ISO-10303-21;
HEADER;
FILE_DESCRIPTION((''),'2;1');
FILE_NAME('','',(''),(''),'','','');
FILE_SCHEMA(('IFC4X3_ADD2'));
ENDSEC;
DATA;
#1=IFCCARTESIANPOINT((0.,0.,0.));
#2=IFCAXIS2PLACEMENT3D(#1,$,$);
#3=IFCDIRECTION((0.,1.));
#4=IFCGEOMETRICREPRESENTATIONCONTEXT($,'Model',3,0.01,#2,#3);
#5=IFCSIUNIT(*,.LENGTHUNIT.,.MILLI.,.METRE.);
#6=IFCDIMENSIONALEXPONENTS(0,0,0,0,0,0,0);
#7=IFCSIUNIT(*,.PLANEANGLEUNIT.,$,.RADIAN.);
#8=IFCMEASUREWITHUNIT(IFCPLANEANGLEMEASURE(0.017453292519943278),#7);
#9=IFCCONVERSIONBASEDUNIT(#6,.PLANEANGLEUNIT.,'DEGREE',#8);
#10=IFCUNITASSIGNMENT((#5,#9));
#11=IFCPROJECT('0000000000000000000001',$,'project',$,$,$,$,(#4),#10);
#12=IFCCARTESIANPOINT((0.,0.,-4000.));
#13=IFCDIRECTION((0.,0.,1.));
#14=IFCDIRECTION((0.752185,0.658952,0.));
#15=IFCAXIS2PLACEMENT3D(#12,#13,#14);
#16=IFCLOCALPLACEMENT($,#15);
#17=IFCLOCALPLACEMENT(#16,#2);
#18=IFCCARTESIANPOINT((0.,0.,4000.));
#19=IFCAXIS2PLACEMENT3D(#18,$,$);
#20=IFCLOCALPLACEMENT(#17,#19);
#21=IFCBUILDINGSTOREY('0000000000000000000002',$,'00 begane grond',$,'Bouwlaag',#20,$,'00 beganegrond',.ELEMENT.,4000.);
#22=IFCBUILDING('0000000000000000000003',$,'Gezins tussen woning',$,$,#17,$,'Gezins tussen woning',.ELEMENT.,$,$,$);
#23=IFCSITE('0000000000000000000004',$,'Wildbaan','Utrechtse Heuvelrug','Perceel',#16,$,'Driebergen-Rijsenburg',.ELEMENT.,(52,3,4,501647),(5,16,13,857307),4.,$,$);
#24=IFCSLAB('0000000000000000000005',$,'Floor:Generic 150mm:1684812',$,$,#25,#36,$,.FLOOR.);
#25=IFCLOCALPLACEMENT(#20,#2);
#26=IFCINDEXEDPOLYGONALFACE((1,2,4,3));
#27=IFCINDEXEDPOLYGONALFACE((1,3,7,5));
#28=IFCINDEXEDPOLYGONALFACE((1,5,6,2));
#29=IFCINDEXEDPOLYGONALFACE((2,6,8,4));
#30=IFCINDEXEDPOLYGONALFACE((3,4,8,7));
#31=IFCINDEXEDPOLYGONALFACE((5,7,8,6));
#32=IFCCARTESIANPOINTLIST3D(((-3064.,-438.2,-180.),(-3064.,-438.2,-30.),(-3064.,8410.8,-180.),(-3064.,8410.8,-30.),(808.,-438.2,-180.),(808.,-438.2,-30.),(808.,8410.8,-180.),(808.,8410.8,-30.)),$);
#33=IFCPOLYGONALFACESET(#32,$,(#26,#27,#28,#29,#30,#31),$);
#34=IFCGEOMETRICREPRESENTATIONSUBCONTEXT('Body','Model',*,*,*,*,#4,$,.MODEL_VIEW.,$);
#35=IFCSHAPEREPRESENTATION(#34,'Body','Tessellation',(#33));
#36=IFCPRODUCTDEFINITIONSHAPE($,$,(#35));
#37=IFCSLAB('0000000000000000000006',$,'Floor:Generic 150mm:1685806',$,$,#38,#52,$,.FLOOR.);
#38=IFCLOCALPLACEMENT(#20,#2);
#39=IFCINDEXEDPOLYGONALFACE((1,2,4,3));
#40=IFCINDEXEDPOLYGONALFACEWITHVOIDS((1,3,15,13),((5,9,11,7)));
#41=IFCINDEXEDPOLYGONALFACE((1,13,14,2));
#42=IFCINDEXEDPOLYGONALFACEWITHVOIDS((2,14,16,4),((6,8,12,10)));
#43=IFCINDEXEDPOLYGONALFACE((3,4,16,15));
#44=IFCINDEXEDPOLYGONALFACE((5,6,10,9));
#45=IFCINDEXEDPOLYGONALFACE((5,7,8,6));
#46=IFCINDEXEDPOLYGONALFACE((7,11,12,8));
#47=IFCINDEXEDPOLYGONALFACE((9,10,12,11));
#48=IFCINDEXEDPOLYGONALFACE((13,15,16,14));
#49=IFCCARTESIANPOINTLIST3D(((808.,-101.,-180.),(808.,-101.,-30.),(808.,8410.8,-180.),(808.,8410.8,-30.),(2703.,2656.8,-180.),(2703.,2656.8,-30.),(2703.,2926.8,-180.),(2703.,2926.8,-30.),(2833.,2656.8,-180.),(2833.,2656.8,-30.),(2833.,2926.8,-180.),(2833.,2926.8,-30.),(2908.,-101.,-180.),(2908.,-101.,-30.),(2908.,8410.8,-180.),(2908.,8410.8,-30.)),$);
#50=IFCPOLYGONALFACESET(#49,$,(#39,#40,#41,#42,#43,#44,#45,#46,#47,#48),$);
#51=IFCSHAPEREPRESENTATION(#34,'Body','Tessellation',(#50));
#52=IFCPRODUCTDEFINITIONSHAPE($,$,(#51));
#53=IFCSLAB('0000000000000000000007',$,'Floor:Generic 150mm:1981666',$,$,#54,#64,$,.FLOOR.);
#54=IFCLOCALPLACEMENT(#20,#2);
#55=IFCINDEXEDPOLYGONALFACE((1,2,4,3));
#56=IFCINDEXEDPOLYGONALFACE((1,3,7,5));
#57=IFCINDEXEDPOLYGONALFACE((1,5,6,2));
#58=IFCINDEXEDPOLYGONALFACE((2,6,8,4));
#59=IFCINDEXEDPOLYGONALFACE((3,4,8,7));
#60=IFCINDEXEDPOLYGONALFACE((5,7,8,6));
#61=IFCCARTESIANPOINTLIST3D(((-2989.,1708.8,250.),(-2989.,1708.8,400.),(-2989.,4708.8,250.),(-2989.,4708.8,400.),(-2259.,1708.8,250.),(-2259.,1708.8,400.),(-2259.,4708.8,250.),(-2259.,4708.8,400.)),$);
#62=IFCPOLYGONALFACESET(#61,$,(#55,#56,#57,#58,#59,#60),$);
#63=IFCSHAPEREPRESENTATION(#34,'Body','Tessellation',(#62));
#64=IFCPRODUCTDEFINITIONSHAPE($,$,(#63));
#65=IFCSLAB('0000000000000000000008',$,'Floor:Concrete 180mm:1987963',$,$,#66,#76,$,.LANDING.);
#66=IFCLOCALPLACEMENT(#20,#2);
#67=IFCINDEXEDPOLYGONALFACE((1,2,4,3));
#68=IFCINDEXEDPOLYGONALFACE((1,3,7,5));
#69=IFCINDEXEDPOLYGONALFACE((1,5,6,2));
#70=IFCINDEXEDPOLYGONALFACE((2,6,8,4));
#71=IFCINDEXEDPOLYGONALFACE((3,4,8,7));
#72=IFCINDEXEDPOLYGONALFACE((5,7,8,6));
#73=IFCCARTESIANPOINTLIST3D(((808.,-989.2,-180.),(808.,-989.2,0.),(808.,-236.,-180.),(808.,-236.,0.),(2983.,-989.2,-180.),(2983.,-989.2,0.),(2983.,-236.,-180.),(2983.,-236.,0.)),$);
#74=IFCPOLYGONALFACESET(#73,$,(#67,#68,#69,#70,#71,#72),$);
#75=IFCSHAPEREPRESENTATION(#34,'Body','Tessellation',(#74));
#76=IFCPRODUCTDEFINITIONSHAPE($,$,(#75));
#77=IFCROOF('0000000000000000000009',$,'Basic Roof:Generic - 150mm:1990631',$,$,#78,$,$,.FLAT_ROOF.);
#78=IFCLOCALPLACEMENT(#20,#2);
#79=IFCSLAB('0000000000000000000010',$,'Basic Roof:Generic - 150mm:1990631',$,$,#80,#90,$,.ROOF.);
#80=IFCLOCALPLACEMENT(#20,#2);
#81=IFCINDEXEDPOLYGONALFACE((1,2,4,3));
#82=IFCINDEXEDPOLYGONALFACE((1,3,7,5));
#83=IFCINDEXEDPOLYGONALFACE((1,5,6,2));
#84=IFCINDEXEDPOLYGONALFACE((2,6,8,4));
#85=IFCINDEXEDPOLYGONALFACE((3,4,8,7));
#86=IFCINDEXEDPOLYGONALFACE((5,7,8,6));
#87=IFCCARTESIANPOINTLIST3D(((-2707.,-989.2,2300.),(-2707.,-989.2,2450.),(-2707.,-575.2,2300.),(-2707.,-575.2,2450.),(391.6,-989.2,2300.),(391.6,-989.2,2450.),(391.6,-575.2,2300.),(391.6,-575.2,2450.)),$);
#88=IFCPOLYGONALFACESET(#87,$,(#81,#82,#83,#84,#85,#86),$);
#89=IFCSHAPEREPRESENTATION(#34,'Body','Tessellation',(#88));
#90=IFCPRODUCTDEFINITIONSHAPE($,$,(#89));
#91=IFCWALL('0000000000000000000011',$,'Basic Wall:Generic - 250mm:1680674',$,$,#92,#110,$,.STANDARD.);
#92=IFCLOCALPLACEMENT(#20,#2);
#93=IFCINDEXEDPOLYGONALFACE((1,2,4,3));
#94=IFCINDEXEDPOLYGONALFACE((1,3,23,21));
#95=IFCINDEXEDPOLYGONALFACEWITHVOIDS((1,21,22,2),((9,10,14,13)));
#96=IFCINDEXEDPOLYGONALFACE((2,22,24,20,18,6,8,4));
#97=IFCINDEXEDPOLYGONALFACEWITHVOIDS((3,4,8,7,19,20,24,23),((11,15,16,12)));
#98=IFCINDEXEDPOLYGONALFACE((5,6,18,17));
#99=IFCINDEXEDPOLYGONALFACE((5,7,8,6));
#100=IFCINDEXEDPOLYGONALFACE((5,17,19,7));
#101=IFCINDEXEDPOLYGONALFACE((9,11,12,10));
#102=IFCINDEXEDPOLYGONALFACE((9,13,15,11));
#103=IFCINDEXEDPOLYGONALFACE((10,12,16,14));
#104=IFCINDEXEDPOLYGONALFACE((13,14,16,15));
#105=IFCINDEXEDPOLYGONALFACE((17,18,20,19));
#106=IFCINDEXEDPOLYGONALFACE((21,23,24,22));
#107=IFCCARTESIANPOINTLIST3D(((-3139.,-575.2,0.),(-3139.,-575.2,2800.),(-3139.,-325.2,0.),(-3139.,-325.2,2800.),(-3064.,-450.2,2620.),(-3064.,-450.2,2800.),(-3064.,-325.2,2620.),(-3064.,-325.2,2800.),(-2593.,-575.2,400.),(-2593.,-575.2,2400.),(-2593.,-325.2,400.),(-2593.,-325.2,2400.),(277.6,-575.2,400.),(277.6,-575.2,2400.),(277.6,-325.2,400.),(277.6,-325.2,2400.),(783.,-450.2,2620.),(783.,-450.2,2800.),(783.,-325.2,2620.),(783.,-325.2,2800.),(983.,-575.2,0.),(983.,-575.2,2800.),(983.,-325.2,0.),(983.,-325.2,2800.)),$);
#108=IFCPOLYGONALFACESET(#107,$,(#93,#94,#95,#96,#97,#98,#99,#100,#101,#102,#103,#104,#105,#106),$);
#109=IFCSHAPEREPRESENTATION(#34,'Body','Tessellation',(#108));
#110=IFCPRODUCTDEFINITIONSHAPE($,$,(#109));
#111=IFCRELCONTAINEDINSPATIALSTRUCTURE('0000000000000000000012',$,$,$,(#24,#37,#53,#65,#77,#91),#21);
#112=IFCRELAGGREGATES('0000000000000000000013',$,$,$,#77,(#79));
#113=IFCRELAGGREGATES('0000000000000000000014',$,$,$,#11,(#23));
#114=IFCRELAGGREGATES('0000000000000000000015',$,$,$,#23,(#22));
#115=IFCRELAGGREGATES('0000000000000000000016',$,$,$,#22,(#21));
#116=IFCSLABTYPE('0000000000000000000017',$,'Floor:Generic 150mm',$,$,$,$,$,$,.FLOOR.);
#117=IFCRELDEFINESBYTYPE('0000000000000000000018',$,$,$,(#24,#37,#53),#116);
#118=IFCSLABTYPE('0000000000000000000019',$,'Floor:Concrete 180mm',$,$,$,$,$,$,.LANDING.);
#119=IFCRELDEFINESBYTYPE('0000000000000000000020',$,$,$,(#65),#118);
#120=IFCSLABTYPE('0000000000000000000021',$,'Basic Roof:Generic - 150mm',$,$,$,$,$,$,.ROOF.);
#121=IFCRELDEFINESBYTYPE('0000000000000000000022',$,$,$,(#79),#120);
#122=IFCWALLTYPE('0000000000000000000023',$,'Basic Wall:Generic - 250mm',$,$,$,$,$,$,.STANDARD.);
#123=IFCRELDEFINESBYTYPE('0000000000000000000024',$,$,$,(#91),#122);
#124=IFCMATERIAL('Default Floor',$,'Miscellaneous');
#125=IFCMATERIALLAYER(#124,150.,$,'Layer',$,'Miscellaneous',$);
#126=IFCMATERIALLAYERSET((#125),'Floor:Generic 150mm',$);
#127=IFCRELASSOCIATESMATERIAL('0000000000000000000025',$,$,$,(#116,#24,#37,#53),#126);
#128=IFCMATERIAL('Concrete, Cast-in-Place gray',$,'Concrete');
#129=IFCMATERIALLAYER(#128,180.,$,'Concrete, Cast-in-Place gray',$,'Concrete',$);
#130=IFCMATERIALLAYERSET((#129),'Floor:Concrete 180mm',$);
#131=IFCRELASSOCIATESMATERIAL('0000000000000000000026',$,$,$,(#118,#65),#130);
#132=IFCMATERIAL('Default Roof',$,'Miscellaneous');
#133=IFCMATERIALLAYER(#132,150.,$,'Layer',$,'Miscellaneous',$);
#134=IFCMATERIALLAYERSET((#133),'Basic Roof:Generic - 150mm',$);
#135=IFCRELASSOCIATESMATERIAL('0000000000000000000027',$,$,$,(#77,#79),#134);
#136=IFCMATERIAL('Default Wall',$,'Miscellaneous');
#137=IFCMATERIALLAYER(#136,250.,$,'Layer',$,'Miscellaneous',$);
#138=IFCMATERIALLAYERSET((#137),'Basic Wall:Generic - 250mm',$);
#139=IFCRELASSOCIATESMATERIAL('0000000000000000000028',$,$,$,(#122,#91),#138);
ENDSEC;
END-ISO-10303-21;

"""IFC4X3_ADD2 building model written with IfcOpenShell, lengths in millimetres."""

from ifc_helpers import new_model, entity, si_unit, converted_unit, direction, frame, frame_2d, origin, origin_2d_with_axis, place, context, subcontext, project, spatial, polyline, rectangle, extrude, boolean, clip, bounded_halfspace, material, layer, layer_set, layer_usage, type_object, element, aggregate, save


model = new_model("IFC4X3_ADD2")

# Units and contexts
model_context = context("Model", 3, precision=0.01, world=origin(), true_north=direction((0.0, 1.0)))
body_context = subcontext(model_context, "Body", "Model", "MODEL_VIEW")
ifc_project = project(units=[si_unit("LENGTHUNIT", "METRE", prefix="MILLI"), converted_unit("PLANEANGLEUNIT", "DEGREE", entity("IfcPlaneAngleMeasure", 0.017453292519943278), si_unit("PLANEANGLEUNIT", "RADIAN"), dimensions=[0, 0, 0, 0, 0, 0, 0])], contexts=[model_context])

# Site, building, storey
site_placement = place(None, frame((0.0, 0.0, -4000.0), z_axis=(0.0, 0.0, 1.0), x_axis=(0.752185, 0.658952, 0.0)))
site = spatial("IfcSite", under=ifc_project, at=site_placement, Name="Wildbaan", Description="Utrechtse Heuvelrug", ObjectType="Perceel", LongName="Driebergen-Rijsenburg", CompositionType="ELEMENT", RefLatitude=(52, 3, 4, 501647), RefLongitude=(5, 16, 13, 857307), RefElevation=4.0)
building_placement = place(site_placement, origin())
building = spatial("IfcBuilding", under=site, at=building_placement, Name="Gezins tussen woning", LongName="Gezins tussen woning", CompositionType="ELEMENT")
storey_placement = place(building_placement, frame((0.0, 0.0, 4000.0)))
storey = spatial("IfcBuildingStorey", under=building, at=storey_placement, Name="00 begane grond", ObjectType="Bouwlaag", LongName="00 beganegrond", CompositionType="ELEMENT", Elevation=4000.0)

# Slab
ifc_material_1 = material(Name="Default Floor", Category="Miscellaneous")
ifc_layer_1 = layer(ifc_material_1, 150.0, Name="Layer", Category="Miscellaneous")
ifc_layer_set_1 = layer_set([ifc_layer_1], Name="Floor:Generic 150mm")
ifc_layer_usage_1 = layer_usage(ifc_layer_set_1, "AXIS3", "POSITIVE", 0.0)
slab_type_1 = type_object("IfcSlabType", Name="Floor:Generic 150mm", PredefinedType="FLOOR", material=ifc_layer_set_1)
slab_1_placement = place(storey_placement, origin())
element("IfcSlab", 1, at=slab_1_placement, inside=storey, type_object=slab_type_1, material=ifc_layer_usage_1, Name="Floor:Generic 150mm:1684812", PredefinedType="FLOOR", context=body_context, shape_type="SweptSolid", body=[
    extrude(rectangle(XDim=8849.0, YDim=3872.0, at=frame_2d((0.0, 0.0), x_axis=(1.0, 0.0))), frame((-1128.0, 3986.3, -30.0), z_axis=(0.0, 0.0, -1.0), x_axis=(0.0, 1.0, 0.0)), (0.0, 0.0, 1.0), 150.0),
])

# Slab, opening
ifc_layer_usage_2 = layer_usage(ifc_layer_set_1, "AXIS3", "POSITIVE", 0.0)
slab_2_placement = place(storey_placement, origin())
slab_2 = element("IfcSlab", 2, at=slab_2_placement, inside=storey, type_object=slab_type_1, material=ifc_layer_usage_2, Name="Floor:Generic 150mm:1685806", PredefinedType="FLOOR", context=body_context, shape_type="CSG", body=[
    boolean("DIFFERENCE", extrude(rectangle(XDim=8511.8, YDim=2100.0, at=frame_2d((0.0, 0.0), x_axis=(1.0, 0.0))), frame((1858.0, 4154.9, -30.0), z_axis=(0.0, 0.0, -1.0), x_axis=(0.0, 1.0, 0.0)), (0.0, 0.0, 1.0), 150.0), extrude(rectangle(XDim=270.0, YDim=130.0, at=frame_2d((0.0, 0.0), x_axis=(1.0, 0.0))), frame((2768.0, 2791.8, -30.0), z_axis=(0.0, 0.0, -1.0), x_axis=(0.0, -1.0, 0.0)), (0.0, 0.0, 1.0), 150.0)),
])
opening_1_placement = place(slab_2_placement, origin())
element("IfcOpeningElement", 3, at=opening_1_placement, cuts=slab_2, PredefinedType="OPENING", context=body_context, shape_type="SweptSolid", body=[
    extrude(rectangle(XDim=270.0, YDim=130.0, at=frame_2d((2768.0, 2791.8), x_axis=(0.0, -1.0))), frame((0.0, 0.0, -30.0)), (0.0, 0.0, -1.0), 150.0),
])

# Slabs
ifc_layer_usage_3 = layer_usage(ifc_layer_set_1, "AXIS3", "POSITIVE", 0.0)
slab_3_placement = place(storey_placement, origin())
element("IfcSlab", 4, at=slab_3_placement, inside=storey, type_object=slab_type_1, material=ifc_layer_usage_3, Name="Floor:Generic 150mm:1981666", PredefinedType="FLOOR", context=body_context, shape_type="SweptSolid", body=[
    extrude(rectangle(XDim=3000.0, YDim=730.0, at=frame_2d((0.0, 0.0), x_axis=(1.0, 0.0))), frame((-2624.0, 3208.8, 400.0), z_axis=(0.0, 0.0, -1.0), x_axis=(0.0, 1.0, 0.0)), (0.0, 0.0, 1.0), 150.0),
])
ifc_material_2 = material(Name="Concrete, Cast-in-Place gray", Category="Concrete")
ifc_layer_2 = layer(ifc_material_2, 180.0, Name="Concrete, Cast-in-Place gray", Category="Concrete")
ifc_layer_set_2 = layer_set([ifc_layer_2], Name="Floor:Concrete 180mm")
ifc_layer_usage_4 = layer_usage(ifc_layer_set_2, "AXIS3", "POSITIVE", 0.0)
slab_type_2 = type_object("IfcSlabType", Name="Floor:Concrete 180mm", PredefinedType="LANDING", material=ifc_layer_set_2)
slab_4_placement = place(storey_placement, origin())
element("IfcSlab", 5, at=slab_4_placement, inside=storey, type_object=slab_type_2, material=ifc_layer_usage_4, Name="Floor:Concrete 180mm:1987963", PredefinedType="LANDING", context=body_context, shape_type="SweptSolid", body=[
    extrude(rectangle(XDim=753.2, YDim=2175.0, at=origin_2d_with_axis()), frame((1895.5, -612.6, 0.0), z_axis=(0.0, 0.0, -1.0), x_axis=(0.0, 1.0, 0.0)), (0.0, 0.0, 1.0), 180.0),
])

# Roof, slab
ifc_material_3 = material(Name="Default Roof", Category="Miscellaneous")
ifc_layer_3 = layer(ifc_material_3, 150.0, Name="Layer", Category="Miscellaneous")
ifc_layer_set_3 = layer_set([ifc_layer_3], Name="Basic Roof:Generic - 150mm")
roof_placement = place(storey_placement, frame((-2707.0, -989.2, 2300.0)))
roof = element("IfcRoof", 6, at=roof_placement, inside=storey, material=ifc_layer_set_3, Name="Basic Roof:Generic - 150mm:1990631", PredefinedType="FLAT_ROOF")
slab_type_3 = type_object("IfcSlabType", Name="Basic Roof:Generic - 150mm", PredefinedType="ROOF")
slab_5_placement = place(roof_placement, origin())
slab_5 = element("IfcSlab", 7, at=slab_5_placement, type_object=slab_type_3, material=ifc_layer_set_3, Name="Basic Roof:Generic - 150mm:1990631", PredefinedType="ROOF", context=body_context, shape_type="SweptSolid", body=[
    extrude(rectangle(XDim=3098.6, YDim=414.0, at=origin_2d_with_axis()), frame((1549.3, 207.0, 0.0)), (0.0, 0.0, 1.0), 150.0),
])
aggregate(roof, [slab_5])

# Wall, opening
ifc_material_4 = material(Name="Default Wall", Category="Miscellaneous")
ifc_layer_4 = layer(ifc_material_4, 250.0, Name="Layer", Category="Miscellaneous")
ifc_layer_set_4 = layer_set([ifc_layer_4], Name="Basic Wall:Generic - 250mm")
wall_type = type_object("IfcWallType", Name="Basic Wall:Generic - 250mm", PredefinedType="STANDARD", material=ifc_layer_set_4)
wall_placement = place(storey_placement, frame((-3139.0, -450.2, 0.0)))
wall = element("IfcWall", 8, at=wall_placement, inside=storey, type_object=wall_type, material=ifc_layer_set_4, Name="Basic Wall:Generic - 250mm:1680674", PredefinedType="STANDARD", context=body_context, shape_type="Clipping", body=[
    clip(extrude(rectangle(XDim=4122.0, YDim=250.0, at=frame_2d((2061.0, 0.0), x_axis=(-1.0, 0.0))), origin(), (0.0, 0.0, 1.0), 2800.0), bounded_halfspace(frame((3922.0, 0.0, 2620.0), z_axis=(0.0, 0.0, -1.0), x_axis=(0.0, -1.0, 0.0)), True, frame((3922.0, 0.0, 2620.0)), polyline([(0.0, 0.0), (0.0, 125.0), (-50.0, 125.0), (-3772.0, 125.0), (-3847.0, 125.0), (-3847.0, 0.0), (0.0, 0.0)]))),
])
opening_2_placement = place(wall_placement, frame((3139.0, 450.2, 400.0)))
element("IfcOpeningElement", 9, at=opening_2_placement, cuts=wall, PredefinedType="OPENING", context=body_context, shape_type="SweptSolid", body=[
    extrude(rectangle(XDim=2000.0, YDim=2870.6, at=frame_2d((0.0, 0.0), x_axis=(0.0, 1.0))), frame((-1157.7, -575.2, 1000.0), z_axis=(0.0, 1.0, 0.0), x_axis=(1.0, 0.0, 0.0)), (0.0, 0.0, 1.0), 250.0),
])

save(model, "model.ifc")
